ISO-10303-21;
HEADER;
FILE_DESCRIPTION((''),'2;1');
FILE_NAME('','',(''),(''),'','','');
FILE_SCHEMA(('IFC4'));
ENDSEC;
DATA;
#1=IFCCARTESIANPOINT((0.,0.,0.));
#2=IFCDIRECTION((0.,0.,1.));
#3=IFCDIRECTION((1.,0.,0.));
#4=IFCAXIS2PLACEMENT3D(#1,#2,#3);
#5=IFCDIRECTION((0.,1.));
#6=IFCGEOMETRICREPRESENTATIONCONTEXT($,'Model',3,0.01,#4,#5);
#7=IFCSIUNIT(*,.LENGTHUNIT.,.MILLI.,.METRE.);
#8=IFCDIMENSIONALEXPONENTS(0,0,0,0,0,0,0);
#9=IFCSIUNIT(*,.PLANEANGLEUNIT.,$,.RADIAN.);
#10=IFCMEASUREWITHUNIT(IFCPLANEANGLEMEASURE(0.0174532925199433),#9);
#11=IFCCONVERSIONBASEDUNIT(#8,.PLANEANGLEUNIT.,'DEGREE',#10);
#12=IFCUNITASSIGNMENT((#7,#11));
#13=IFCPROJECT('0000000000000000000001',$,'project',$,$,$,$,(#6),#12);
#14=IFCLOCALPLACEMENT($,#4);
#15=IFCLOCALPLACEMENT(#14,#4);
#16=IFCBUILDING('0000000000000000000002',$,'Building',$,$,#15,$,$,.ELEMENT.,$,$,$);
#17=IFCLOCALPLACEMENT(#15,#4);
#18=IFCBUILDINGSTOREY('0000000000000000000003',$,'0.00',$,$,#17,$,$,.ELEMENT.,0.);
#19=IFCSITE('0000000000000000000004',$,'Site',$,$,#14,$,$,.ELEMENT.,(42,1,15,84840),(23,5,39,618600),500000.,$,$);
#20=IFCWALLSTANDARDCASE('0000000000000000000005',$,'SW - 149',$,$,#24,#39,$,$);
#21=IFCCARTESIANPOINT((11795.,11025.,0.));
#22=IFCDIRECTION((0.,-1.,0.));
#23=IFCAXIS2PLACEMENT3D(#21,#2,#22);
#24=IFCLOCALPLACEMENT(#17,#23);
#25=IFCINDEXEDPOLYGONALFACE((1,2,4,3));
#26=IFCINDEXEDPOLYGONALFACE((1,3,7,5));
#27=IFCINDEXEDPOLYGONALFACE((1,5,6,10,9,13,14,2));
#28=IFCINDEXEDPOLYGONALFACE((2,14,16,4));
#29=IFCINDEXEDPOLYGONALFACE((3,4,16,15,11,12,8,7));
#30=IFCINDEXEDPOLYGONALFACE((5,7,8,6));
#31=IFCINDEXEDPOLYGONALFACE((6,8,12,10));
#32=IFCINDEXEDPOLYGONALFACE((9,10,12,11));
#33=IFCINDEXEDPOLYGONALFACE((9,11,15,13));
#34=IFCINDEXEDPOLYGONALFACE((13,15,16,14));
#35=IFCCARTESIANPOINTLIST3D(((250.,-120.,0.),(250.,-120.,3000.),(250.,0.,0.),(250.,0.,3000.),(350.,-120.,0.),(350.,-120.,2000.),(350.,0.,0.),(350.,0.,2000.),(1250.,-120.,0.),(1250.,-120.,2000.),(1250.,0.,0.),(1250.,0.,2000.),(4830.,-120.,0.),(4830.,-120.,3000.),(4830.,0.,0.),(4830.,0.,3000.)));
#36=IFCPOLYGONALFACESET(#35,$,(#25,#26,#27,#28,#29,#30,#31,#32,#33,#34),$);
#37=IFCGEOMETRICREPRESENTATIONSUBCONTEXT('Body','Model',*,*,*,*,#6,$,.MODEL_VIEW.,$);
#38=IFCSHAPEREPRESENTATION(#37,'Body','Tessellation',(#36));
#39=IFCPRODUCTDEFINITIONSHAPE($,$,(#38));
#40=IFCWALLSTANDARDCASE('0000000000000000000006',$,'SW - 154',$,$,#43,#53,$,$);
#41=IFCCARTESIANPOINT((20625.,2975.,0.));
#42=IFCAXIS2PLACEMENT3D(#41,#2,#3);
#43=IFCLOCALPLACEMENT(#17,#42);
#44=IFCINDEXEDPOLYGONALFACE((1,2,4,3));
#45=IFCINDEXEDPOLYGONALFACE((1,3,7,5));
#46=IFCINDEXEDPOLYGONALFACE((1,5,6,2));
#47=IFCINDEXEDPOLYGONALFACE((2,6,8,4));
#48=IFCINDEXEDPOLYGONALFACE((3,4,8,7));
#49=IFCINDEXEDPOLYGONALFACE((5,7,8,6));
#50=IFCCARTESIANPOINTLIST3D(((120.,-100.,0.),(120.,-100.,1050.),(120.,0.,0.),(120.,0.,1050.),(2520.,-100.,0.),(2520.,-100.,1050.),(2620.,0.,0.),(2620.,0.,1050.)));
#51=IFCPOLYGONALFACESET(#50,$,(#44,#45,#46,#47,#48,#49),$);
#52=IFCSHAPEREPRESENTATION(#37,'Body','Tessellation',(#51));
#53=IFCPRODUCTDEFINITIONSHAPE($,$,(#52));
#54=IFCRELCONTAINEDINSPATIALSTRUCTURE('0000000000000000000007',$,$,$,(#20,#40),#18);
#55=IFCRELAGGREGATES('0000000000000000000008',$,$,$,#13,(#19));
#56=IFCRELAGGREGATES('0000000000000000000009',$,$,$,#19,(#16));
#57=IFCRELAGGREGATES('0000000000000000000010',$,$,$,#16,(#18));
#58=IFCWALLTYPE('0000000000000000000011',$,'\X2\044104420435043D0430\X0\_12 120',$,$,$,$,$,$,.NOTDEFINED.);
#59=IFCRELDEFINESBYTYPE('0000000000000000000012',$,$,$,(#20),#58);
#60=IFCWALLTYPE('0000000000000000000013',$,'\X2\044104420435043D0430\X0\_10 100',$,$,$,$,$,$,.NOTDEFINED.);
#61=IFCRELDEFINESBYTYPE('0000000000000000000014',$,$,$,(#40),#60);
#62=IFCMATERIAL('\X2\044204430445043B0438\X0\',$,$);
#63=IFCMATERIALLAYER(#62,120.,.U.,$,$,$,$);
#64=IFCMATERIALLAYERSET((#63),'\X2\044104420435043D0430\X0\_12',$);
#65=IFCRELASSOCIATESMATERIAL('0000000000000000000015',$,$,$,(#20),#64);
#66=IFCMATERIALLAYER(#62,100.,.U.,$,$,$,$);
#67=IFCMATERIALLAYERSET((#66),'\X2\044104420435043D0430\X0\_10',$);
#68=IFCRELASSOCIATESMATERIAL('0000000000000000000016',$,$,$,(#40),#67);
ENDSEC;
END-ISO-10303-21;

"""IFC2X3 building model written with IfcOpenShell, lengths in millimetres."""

from ifc_helpers import new_model, entity, si_unit, converted_unit, direction, frame, origin_with_axes, origin_2d_with_axis, place, context, subcontext, project, spatial, polyline, rectangle, outline, extrude, material, layer, layer_set, layer_usage, type_object, element, save


model = new_model("IFC2X3")

# Units and contexts
model_context = context("Model", 3, precision=0.01, world=origin_with_axes(), true_north=direction((0.0, 1.0)))
body_context = subcontext(model_context, "Body", "Model", "MODEL_VIEW")
ifc_project = project(units=[si_unit("LENGTHUNIT", "METRE", prefix="MILLI"), converted_unit("PLANEANGLEUNIT", "DEGREE", entity("IfcPlaneAngleMeasure", 0.0174532925199433), si_unit("PLANEANGLEUNIT", "RADIAN"), dimensions=[0, 0, 0, 0, 0, 0, 0])], contexts=[model_context])

# Site, building, storey
site_placement = place(None, origin_with_axes())
site = spatial("IfcSite", under=ifc_project, at=site_placement, Name="Site", CompositionType="ELEMENT", RefLatitude=(42, 1, 15, 84840), RefLongitude=(23, 5, 39, 618600), RefElevation=500000.0)
building_placement = place(site_placement, origin_with_axes())
building = spatial("IfcBuilding", under=site, at=building_placement, Name="Building", CompositionType="ELEMENT")
storey_placement = place(building_placement, origin_with_axes())
storey = spatial("IfcBuildingStorey", under=building, at=storey_placement, Name="0.00", CompositionType="ELEMENT", Elevation=0.0)

# Shared definitions
ifc_material_1 = material(Name="тухли")

# Shared definitions
ifc_layer_1 = layer(ifc_material_1, 120.0, ventilated="UNKNOWN")
ifc_layer_set_1 = layer_set([ifc_layer_1], Name="стена_12")
wall_type_1 = type_object("IfcWallType", Name="стена_12 120", PredefinedType="NOTDEFINED")

# Wall, opening
ifc_layer_usage_1 = layer_usage(ifc_layer_set_1, "AXIS2", "NEGATIVE", 0.0)
wall_1_placement = place(storey_placement, frame((11795.0, 11025.0, 0.0), z_axis=(0.0, 0.0, 1.0), x_axis=(0.0, -1.0, 0.0)))
wall_1 = element("IfcWallStandardCase", 1, at=wall_1_placement, inside=storey, type_object=wall_type_1, material=ifc_layer_usage_1, Name="SW - 149", context=body_context, shape_type="SweptSolid", body=[
    extrude(outline(polyline([(250.0, -120.0), (4830.0, -120.0), (4830.0, 0.0), (250.0, 0.0), (250.0, -120.0)])), origin_with_axes(), (0.0, 0.0, 1.0), 3000.0),
])
opening_1_placement = place(wall_1_placement, frame((800.0, 0.0, 0.0), z_axis=(0.0, 0.0, 1.0), x_axis=(1.0, 0.0, 0.0)))
element("IfcOpeningElement", 2, at=opening_1_placement, cuts=wall_1, context=body_context, shape_type="SweptSolid", body=[
    extrude(rectangle(XDim=900.0, YDim=2000.0, at=origin_2d_with_axis()), frame((0.0, -120.0, 1000.0), z_axis=(0.0, -1.0, 0.0), x_axis=(-1.0, 0.0, 0.0)), (0.0, 0.0, -1.0), 360.0),
])

# Wall
ifc_layer_2 = layer(ifc_material_1, 100.0, ventilated="UNKNOWN")
ifc_layer_set_2 = layer_set([ifc_layer_2], Name="стена_10")
wall_type_2 = type_object("IfcWallType", Name="стена_10 100", PredefinedType="NOTDEFINED")
ifc_layer_usage_2 = layer_usage(ifc_layer_set_2, "AXIS2", "NEGATIVE", 0.0)
wall_2_placement = place(storey_placement, frame((20625.0, 2975.0, 0.0), z_axis=(0.0, 0.0, 1.0), x_axis=(1.0, 0.0, 0.0)))
element("IfcWallStandardCase", 3, at=wall_2_placement, inside=storey, type_object=wall_type_2, material=ifc_layer_usage_2, Name="SW - 154", context=body_context, shape_type="SweptSolid", body=[
    extrude(outline(polyline([(120.0, -100.0), (2520.0, -100.0), (2620.0, 0.0), (120.0, 0.0), (120.0, -100.0)])), origin_with_axes(), (0.0, 0.0, 1.0), 1050.0),
])

save(model, "model.ifc")
